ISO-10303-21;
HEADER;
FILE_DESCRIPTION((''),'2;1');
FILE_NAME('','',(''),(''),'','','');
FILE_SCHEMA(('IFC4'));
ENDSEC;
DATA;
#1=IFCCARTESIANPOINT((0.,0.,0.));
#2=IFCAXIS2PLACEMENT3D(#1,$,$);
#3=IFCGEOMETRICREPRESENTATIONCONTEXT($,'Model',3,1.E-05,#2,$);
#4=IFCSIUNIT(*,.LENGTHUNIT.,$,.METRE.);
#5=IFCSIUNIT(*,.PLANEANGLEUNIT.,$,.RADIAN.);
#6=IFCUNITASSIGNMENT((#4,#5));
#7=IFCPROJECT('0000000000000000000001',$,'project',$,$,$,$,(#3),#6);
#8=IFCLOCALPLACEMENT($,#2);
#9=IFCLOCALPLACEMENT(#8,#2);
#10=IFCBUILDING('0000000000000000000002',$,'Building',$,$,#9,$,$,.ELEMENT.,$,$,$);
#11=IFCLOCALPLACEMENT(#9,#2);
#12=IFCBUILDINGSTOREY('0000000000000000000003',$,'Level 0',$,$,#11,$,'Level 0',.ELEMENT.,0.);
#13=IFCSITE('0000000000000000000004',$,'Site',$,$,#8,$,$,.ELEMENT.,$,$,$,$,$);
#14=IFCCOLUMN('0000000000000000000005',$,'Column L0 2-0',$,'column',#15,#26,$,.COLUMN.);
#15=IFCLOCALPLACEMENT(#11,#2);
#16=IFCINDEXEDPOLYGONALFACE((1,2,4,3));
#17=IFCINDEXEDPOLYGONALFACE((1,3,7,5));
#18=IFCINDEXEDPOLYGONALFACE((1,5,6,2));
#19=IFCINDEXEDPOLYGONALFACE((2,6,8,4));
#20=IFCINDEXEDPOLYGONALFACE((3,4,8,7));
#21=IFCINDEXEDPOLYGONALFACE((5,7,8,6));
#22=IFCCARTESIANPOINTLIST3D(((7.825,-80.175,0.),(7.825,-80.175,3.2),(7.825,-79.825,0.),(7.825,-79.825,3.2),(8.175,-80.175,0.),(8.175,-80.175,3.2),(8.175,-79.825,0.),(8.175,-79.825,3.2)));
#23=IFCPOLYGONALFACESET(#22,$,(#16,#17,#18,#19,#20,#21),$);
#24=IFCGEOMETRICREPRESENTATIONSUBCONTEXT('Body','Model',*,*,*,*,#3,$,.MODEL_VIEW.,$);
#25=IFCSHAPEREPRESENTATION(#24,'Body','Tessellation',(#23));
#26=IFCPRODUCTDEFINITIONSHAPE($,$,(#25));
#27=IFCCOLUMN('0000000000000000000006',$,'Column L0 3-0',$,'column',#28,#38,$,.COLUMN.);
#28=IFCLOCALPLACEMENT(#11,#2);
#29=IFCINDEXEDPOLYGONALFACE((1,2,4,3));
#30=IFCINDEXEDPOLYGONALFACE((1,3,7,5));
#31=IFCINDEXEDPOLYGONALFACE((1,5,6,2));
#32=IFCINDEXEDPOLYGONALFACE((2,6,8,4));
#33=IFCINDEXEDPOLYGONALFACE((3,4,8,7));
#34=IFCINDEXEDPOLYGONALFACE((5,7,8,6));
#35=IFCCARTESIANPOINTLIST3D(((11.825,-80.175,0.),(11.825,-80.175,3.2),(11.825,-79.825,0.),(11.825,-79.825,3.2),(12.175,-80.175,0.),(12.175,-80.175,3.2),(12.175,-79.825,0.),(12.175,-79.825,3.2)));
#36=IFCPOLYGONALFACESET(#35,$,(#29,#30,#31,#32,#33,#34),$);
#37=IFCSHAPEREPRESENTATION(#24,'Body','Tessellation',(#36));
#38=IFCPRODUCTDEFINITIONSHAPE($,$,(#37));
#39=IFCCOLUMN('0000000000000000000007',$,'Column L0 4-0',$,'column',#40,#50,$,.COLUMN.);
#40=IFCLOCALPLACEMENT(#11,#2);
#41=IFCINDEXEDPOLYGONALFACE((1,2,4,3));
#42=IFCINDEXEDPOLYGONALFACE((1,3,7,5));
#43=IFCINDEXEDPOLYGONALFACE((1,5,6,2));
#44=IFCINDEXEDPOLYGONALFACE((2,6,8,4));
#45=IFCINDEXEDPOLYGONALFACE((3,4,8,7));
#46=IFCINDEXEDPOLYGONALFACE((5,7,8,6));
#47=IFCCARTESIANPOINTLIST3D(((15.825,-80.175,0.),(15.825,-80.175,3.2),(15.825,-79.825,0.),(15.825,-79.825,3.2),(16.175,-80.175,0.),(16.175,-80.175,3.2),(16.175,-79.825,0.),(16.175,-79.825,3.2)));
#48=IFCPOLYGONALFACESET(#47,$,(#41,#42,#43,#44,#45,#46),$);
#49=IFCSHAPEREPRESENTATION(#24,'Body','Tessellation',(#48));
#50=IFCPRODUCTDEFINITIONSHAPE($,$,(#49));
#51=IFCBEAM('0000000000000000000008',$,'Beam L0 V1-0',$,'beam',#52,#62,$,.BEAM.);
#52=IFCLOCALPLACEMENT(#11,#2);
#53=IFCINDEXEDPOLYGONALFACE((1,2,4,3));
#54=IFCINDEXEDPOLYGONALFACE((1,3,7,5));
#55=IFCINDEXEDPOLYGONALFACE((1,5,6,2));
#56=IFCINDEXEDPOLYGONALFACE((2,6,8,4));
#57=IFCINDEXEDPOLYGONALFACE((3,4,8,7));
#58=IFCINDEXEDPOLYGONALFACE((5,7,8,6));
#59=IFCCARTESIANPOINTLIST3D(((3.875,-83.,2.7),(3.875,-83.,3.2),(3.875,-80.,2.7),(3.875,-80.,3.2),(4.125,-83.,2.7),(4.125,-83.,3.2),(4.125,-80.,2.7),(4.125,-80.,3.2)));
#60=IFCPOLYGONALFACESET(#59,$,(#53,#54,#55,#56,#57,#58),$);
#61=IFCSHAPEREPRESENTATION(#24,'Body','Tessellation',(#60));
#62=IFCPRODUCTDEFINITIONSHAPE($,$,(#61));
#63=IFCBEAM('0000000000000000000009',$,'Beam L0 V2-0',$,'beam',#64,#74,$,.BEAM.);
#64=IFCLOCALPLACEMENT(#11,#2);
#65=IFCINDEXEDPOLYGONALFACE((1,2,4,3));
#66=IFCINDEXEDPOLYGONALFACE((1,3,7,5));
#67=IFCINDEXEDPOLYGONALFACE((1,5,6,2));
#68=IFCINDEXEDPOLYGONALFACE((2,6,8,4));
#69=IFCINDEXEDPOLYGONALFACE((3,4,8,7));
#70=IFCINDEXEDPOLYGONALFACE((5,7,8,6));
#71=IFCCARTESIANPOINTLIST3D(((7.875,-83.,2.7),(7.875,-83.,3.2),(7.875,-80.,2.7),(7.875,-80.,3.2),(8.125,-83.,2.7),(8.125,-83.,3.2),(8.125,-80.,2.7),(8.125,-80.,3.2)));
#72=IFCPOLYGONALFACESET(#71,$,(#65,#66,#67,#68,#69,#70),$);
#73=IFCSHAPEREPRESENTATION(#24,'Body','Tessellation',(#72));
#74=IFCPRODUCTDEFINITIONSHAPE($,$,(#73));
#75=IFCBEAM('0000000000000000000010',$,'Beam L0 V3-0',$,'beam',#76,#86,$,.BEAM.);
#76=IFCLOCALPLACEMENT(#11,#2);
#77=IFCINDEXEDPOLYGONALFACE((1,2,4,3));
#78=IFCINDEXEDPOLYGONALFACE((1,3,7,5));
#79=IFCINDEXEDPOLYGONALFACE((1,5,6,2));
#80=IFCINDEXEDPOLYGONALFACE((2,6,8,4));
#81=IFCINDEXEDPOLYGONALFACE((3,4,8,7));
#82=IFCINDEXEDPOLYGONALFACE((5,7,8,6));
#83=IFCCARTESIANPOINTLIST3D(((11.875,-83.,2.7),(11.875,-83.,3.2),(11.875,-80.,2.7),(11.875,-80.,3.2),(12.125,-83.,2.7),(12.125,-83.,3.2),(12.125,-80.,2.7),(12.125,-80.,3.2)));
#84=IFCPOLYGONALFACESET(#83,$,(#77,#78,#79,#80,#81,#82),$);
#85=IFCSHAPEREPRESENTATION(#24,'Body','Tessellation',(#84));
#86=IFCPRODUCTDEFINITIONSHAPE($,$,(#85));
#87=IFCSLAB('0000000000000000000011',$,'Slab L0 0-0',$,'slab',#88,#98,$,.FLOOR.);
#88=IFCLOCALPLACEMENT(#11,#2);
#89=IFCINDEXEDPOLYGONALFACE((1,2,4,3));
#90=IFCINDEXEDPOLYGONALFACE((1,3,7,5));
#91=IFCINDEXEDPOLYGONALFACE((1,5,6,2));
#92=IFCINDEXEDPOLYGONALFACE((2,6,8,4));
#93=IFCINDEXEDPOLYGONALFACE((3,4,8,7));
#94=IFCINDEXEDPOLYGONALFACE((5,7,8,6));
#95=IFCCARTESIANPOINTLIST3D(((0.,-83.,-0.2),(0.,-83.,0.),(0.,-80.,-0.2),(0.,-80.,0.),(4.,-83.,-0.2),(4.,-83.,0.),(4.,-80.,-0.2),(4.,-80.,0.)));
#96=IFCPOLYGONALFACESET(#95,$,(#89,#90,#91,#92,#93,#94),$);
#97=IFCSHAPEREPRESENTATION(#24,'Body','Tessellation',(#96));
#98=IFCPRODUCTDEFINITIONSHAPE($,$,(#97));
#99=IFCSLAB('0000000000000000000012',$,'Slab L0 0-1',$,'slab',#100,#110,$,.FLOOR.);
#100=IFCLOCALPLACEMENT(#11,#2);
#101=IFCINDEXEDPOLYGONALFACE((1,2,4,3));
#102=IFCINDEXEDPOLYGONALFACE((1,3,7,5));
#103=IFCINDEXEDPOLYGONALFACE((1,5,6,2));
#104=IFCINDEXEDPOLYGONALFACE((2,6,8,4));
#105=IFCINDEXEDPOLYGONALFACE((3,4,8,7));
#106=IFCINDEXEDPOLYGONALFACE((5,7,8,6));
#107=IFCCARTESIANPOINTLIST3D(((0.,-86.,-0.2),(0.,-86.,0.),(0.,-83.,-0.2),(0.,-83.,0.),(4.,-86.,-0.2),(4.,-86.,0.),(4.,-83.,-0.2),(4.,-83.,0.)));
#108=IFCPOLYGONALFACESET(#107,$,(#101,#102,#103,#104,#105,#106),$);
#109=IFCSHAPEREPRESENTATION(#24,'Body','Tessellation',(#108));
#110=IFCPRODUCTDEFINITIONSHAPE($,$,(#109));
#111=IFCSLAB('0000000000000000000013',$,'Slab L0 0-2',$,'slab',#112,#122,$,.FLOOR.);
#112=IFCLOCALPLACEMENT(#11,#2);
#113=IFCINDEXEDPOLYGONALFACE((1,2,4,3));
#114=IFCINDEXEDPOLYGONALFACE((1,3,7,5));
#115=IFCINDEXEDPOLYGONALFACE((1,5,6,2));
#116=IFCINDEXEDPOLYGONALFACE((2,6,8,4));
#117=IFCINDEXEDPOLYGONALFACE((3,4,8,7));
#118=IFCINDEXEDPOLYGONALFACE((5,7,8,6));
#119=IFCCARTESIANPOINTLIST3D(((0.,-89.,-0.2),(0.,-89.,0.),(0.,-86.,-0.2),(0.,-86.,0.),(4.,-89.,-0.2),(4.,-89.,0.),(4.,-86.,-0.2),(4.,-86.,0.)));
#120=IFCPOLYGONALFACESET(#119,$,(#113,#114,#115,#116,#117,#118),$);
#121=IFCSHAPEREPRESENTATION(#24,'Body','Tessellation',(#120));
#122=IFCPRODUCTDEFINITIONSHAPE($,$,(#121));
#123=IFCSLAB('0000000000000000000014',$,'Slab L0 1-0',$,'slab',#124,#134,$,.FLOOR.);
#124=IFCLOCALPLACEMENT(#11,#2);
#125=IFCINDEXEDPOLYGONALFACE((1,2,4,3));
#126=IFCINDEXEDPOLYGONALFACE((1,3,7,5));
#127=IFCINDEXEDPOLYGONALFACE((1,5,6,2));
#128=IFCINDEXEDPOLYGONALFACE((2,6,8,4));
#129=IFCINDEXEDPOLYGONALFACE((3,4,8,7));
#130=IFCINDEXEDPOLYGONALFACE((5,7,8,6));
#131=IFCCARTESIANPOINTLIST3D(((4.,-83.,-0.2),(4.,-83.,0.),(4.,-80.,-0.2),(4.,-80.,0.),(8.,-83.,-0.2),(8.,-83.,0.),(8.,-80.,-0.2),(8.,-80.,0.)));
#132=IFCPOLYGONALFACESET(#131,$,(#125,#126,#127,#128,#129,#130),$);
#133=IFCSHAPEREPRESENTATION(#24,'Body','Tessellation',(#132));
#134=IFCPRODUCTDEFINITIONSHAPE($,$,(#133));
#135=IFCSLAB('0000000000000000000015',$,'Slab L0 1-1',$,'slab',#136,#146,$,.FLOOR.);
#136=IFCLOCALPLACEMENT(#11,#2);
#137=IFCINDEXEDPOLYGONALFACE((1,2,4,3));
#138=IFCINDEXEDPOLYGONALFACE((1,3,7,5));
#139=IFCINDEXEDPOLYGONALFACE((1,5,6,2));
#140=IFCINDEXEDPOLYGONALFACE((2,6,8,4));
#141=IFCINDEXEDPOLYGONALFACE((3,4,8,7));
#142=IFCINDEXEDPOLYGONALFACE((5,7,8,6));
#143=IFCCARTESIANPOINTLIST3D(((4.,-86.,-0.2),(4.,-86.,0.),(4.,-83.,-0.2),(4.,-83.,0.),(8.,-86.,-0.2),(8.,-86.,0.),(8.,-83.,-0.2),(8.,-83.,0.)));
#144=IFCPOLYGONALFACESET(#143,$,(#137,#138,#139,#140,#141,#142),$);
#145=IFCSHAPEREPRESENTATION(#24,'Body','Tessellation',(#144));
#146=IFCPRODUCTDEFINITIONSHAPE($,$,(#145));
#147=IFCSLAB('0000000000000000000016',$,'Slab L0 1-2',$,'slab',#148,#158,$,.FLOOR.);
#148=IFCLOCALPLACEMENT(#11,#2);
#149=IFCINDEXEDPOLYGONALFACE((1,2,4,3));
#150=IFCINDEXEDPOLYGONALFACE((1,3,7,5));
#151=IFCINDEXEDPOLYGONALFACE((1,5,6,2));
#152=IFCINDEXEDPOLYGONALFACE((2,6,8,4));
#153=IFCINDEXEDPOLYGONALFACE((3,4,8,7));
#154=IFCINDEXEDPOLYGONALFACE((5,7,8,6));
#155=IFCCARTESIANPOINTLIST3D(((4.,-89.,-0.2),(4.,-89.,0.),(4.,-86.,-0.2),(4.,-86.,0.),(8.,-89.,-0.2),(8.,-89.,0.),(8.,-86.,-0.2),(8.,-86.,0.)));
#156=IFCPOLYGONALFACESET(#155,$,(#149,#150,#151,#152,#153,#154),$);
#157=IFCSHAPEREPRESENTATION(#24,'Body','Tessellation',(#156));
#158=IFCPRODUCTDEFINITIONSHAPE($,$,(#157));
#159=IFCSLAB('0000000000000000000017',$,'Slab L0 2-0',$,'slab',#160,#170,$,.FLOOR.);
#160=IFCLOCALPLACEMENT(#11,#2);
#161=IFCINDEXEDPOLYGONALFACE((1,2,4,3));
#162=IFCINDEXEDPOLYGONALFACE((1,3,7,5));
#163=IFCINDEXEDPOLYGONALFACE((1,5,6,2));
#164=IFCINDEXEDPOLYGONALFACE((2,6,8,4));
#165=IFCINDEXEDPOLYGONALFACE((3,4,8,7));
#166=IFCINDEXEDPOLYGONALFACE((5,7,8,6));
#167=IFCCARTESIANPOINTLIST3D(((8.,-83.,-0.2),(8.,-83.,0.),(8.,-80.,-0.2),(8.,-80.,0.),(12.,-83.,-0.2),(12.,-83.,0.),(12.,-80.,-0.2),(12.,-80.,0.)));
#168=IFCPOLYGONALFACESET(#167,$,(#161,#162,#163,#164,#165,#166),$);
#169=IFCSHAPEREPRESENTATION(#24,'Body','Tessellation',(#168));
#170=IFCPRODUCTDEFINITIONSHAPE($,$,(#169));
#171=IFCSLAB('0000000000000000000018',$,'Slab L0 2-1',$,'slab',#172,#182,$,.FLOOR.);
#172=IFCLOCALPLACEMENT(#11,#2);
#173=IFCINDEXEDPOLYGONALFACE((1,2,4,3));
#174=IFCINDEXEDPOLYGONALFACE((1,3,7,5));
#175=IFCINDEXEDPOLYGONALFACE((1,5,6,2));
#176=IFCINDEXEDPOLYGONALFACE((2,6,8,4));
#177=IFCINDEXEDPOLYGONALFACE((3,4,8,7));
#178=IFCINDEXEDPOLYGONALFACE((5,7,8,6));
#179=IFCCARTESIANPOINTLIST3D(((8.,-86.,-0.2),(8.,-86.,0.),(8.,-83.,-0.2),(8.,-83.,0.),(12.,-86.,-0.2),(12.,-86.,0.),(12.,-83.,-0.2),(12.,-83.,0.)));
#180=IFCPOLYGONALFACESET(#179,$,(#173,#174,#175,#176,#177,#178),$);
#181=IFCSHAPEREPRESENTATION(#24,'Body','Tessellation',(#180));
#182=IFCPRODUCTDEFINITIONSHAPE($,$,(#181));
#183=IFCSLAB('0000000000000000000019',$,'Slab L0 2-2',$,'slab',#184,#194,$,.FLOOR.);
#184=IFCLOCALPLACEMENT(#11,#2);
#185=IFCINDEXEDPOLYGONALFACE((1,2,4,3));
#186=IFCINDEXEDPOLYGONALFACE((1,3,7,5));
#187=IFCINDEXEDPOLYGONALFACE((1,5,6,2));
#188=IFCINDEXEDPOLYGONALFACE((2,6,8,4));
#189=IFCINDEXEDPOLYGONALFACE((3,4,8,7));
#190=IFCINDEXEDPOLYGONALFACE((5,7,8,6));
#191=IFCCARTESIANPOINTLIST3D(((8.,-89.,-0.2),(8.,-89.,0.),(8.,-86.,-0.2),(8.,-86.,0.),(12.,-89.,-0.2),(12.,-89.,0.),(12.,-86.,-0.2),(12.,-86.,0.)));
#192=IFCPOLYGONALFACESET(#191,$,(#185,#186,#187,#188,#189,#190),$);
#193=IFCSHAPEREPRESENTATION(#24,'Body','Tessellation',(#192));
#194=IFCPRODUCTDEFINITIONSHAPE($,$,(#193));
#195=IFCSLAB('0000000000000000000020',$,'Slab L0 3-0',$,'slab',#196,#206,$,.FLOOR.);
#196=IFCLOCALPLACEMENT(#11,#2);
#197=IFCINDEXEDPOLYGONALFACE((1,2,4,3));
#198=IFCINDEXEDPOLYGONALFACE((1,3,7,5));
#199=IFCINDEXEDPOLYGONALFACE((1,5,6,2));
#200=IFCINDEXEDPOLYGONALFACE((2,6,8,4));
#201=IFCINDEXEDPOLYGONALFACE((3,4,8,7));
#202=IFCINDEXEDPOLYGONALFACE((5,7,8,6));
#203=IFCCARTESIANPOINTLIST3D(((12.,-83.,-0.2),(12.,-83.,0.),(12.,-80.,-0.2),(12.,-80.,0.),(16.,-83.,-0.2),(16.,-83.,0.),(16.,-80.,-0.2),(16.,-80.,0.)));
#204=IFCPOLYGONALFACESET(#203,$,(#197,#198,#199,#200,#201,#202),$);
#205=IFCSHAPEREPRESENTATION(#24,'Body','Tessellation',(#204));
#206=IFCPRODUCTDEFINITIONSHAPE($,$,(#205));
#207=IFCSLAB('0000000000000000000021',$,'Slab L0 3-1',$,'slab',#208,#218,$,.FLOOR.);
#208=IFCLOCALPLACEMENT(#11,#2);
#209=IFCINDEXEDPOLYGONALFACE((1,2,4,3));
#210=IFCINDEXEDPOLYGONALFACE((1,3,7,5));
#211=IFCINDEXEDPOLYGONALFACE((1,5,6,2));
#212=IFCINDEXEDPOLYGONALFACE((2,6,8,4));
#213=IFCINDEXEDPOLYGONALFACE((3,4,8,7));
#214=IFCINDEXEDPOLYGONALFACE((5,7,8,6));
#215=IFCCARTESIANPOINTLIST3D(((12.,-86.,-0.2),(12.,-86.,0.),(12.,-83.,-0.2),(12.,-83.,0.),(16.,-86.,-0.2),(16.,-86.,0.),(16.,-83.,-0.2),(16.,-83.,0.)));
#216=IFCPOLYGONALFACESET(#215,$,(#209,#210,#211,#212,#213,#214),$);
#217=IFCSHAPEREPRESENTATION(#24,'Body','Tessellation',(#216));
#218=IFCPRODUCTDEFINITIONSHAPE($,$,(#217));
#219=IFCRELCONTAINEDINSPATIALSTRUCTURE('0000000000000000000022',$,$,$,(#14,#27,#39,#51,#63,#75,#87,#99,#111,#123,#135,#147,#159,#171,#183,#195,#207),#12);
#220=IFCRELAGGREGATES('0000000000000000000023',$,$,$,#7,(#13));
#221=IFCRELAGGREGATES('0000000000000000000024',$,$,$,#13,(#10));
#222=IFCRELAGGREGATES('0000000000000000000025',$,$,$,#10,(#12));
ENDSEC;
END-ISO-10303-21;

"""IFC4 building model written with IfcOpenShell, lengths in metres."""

from ifc_helpers import new_model, si_unit, frame, origin, origin_2d, place, context, subcontext, project, spatial, polyline, rectangle, outline, extrude, element, save


model = new_model("IFC4")

# Units and contexts
model_context = context("Model", 3, precision=1e-05, world=origin())
body_context = subcontext(model_context, "Body", "Model", "MODEL_VIEW")
ifc_project = project(units=[si_unit("LENGTHUNIT", "METRE"), si_unit("PLANEANGLEUNIT", "RADIAN")], contexts=[model_context])

# Site, building, storey
site_placement = place(None, origin())
site = spatial("IfcSite", under=ifc_project, at=site_placement, Name="Site", CompositionType="ELEMENT")
building_placement = place(site_placement, origin())
building = spatial("IfcBuilding", under=site, at=building_placement, Name="Building", CompositionType="ELEMENT")
storey_placement = place(building_placement, origin())
storey = spatial("IfcBuildingStorey", under=building, at=storey_placement, Name="Level 0", LongName="Level 0", CompositionType="ELEMENT", Elevation=0.0)

# Columns
for number, where, name in (
    (1, (8.0, -80.0, 0.0), "Column L0 2-0"),
    (2, (12.0, -80.0, 0.0), "Column L0 3-0"),
    (3, (16.0, -80.0, 0.0), "Column L0 4-0"),
):
    element("IfcColumn", number, at=place(storey_placement, frame(where)), inside=storey, Name=name, ObjectType="column", PredefinedType="COLUMN", context=body_context, shape_type="SweptSolid", body=[
        extrude(rectangle(XDim=0.35, YDim=0.35, at=origin_2d()), origin(), (0.0, 0.0, 1.0), 3.2),
    ])

# Beams
for number, where, z_axis, x_axis, name in (
    (4, (4.0, -80.0, 2.95), (0.0, -1.0, 0.0), (0.0, 0.0, 1.0), "Beam L0 V1-0"),
    (5, (8.0, -80.0, 2.95), (0.0, -1.0, 0.0), (0.0, 0.0, 1.0), "Beam L0 V2-0"),
    (6, (12.0, -80.0, 2.95), (0.0, -1.0, 0.0), (0.0, 0.0, 1.0), "Beam L0 V3-0"),
):
    element("IfcBeam", number, at=place(storey_placement, frame(where, z_axis=z_axis, x_axis=x_axis)), inside=storey, Name=name, ObjectType="beam", PredefinedType="BEAM", context=body_context, shape_type="SweptSolid", body=[
        extrude(rectangle(XDim=0.5, YDim=0.25, at=origin_2d()), origin(), (0.0, 0.0, 1.0), 3.0),
    ])

# Slabs
slab_1_placement = place(storey_placement, frame((0.0, 0.0, -0.2)))
element("IfcSlab", 7, at=slab_1_placement, inside=storey, Name="Slab L0 0-0", ObjectType="slab", PredefinedType="FLOOR", context=body_context, shape_type="SweptSolid", body=[
    extrude(outline(polyline([(0.0, -83.0), (4.0, -83.0), (4.0, -80.0), (0.0, -80.0), (0.0, -83.0)])), origin(), (0.0, 0.0, 1.0), 0.2),
])
slab_2_placement = place(storey_placement, frame((0.0, 0.0, -0.2)))
element("IfcSlab", 8, at=slab_2_placement, inside=storey, Name="Slab L0 0-1", ObjectType="slab", PredefinedType="FLOOR", context=body_context, shape_type="SweptSolid", body=[
    extrude(outline(polyline([(0.0, -86.0), (4.0, -86.0), (4.0, -83.0), (0.0, -83.0), (0.0, -86.0)])), origin(), (0.0, 0.0, 1.0), 0.2),
])
slab_3_placement = place(storey_placement, frame((0.0, 0.0, -0.2)))
element("IfcSlab", 9, at=slab_3_placement, inside=storey, Name="Slab L0 0-2", ObjectType="slab", PredefinedType="FLOOR", context=body_context, shape_type="SweptSolid", body=[
    extrude(outline(polyline([(0.0, -89.0), (4.0, -89.0), (4.0, -86.0), (0.0, -86.0), (0.0, -89.0)])), origin(), (0.0, 0.0, 1.0), 0.2),
])
slab_4_placement = place(storey_placement, frame((0.0, 0.0, -0.2)))
element("IfcSlab", 10, at=slab_4_placement, inside=storey, Name="Slab L0 1-0", ObjectType="slab", PredefinedType="FLOOR", context=body_context, shape_type="SweptSolid", body=[
    extrude(outline(polyline([(4.0, -83.0), (8.0, -83.0), (8.0, -80.0), (4.0, -80.0), (4.0, -83.0)])), origin(), (0.0, 0.0, 1.0), 0.2),
])
slab_5_placement = place(storey_placement, frame((0.0, 0.0, -0.2)))
element("IfcSlab", 11, at=slab_5_placement, inside=storey, Name="Slab L0 1-1", ObjectType="slab", PredefinedType="FLOOR", context=body_context, shape_type="SweptSolid", body=[
    extrude(outline(polyline([(4.0, -86.0), (8.0, -86.0), (8.0, -83.0), (4.0, -83.0), (4.0, -86.0)])), origin(), (0.0, 0.0, 1.0), 0.2),
])
slab_6_placement = place(storey_placement, frame((0.0, 0.0, -0.2)))
element("IfcSlab", 12, at=slab_6_placement, inside=storey, Name="Slab L0 1-2", ObjectType="slab", PredefinedType="FLOOR", context=body_context, shape_type="SweptSolid", body=[
    extrude(outline(polyline([(4.0, -89.0), (8.0, -89.0), (8.0, -86.0), (4.0, -86.0), (4.0, -89.0)])), origin(), (0.0, 0.0, 1.0), 0.2),
])
slab_7_placement = place(storey_placement, frame((0.0, 0.0, -0.2)))
element("IfcSlab", 13, at=slab_7_placement, inside=storey, Name="Slab L0 2-0", ObjectType="slab", PredefinedType="FLOOR", context=body_context, shape_type="SweptSolid", body=[
    extrude(outline(polyline([(8.0, -83.0), (12.0, -83.0), (12.0, -80.0), (8.0, -80.0), (8.0, -83.0)])), origin(), (0.0, 0.0, 1.0), 0.2),
])
slab_8_placement = place(storey_placement, frame((0.0, 0.0, -0.2)))
element("IfcSlab", 14, at=slab_8_placement, inside=storey, Name="Slab L0 2-1", ObjectType="slab", PredefinedType="FLOOR", context=body_context, shape_type="SweptSolid", body=[
    extrude(outline(polyline([(8.0, -86.0), (12.0, -86.0), (12.0, -83.0), (8.0, -83.0), (8.0, -86.0)])), origin(), (0.0, 0.0, 1.0), 0.2),
])
slab_9_placement = place(storey_placement, frame((0.0, 0.0, -0.2)))
element("IfcSlab", 15, at=slab_9_placement, inside=storey, Name="Slab L0 2-2", ObjectType="slab", PredefinedType="FLOOR", context=body_context, shape_type="SweptSolid", body=[
    extrude(outline(polyline([(8.0, -89.0), (12.0, -89.0), (12.0, -86.0), (8.0, -86.0), (8.0, -89.0)])), origin(), (0.0, 0.0, 1.0), 0.2),
])
slab_10_placement = place(storey_placement, frame((0.0, 0.0, -0.2)))
element("IfcSlab", 16, at=slab_10_placement, inside=storey, Name="Slab L0 3-0", ObjectType="slab", PredefinedType="FLOOR", context=body_context, shape_type="SweptSolid", body=[
    extrude(outline(polyline([(12.0, -83.0), (16.0, -83.0), (16.0, -80.0), (12.0, -80.0), (12.0, -83.0)])), origin(), (0.0, 0.0, 1.0), 0.2),
])
slab_11_placement = place(storey_placement, frame((0.0, 0.0, -0.2)))
element("IfcSlab", 17, at=slab_11_placement, inside=storey, Name="Slab L0 3-1", ObjectType="slab", PredefinedType="FLOOR", context=body_context, shape_type="SweptSolid", body=[
    extrude(outline(polyline([(12.0, -86.0), (16.0, -86.0), (16.0, -83.0), (12.0, -83.0), (12.0, -86.0)])), origin(), (0.0, 0.0, 1.0), 0.2),
])

save(model, "model.ifc")
